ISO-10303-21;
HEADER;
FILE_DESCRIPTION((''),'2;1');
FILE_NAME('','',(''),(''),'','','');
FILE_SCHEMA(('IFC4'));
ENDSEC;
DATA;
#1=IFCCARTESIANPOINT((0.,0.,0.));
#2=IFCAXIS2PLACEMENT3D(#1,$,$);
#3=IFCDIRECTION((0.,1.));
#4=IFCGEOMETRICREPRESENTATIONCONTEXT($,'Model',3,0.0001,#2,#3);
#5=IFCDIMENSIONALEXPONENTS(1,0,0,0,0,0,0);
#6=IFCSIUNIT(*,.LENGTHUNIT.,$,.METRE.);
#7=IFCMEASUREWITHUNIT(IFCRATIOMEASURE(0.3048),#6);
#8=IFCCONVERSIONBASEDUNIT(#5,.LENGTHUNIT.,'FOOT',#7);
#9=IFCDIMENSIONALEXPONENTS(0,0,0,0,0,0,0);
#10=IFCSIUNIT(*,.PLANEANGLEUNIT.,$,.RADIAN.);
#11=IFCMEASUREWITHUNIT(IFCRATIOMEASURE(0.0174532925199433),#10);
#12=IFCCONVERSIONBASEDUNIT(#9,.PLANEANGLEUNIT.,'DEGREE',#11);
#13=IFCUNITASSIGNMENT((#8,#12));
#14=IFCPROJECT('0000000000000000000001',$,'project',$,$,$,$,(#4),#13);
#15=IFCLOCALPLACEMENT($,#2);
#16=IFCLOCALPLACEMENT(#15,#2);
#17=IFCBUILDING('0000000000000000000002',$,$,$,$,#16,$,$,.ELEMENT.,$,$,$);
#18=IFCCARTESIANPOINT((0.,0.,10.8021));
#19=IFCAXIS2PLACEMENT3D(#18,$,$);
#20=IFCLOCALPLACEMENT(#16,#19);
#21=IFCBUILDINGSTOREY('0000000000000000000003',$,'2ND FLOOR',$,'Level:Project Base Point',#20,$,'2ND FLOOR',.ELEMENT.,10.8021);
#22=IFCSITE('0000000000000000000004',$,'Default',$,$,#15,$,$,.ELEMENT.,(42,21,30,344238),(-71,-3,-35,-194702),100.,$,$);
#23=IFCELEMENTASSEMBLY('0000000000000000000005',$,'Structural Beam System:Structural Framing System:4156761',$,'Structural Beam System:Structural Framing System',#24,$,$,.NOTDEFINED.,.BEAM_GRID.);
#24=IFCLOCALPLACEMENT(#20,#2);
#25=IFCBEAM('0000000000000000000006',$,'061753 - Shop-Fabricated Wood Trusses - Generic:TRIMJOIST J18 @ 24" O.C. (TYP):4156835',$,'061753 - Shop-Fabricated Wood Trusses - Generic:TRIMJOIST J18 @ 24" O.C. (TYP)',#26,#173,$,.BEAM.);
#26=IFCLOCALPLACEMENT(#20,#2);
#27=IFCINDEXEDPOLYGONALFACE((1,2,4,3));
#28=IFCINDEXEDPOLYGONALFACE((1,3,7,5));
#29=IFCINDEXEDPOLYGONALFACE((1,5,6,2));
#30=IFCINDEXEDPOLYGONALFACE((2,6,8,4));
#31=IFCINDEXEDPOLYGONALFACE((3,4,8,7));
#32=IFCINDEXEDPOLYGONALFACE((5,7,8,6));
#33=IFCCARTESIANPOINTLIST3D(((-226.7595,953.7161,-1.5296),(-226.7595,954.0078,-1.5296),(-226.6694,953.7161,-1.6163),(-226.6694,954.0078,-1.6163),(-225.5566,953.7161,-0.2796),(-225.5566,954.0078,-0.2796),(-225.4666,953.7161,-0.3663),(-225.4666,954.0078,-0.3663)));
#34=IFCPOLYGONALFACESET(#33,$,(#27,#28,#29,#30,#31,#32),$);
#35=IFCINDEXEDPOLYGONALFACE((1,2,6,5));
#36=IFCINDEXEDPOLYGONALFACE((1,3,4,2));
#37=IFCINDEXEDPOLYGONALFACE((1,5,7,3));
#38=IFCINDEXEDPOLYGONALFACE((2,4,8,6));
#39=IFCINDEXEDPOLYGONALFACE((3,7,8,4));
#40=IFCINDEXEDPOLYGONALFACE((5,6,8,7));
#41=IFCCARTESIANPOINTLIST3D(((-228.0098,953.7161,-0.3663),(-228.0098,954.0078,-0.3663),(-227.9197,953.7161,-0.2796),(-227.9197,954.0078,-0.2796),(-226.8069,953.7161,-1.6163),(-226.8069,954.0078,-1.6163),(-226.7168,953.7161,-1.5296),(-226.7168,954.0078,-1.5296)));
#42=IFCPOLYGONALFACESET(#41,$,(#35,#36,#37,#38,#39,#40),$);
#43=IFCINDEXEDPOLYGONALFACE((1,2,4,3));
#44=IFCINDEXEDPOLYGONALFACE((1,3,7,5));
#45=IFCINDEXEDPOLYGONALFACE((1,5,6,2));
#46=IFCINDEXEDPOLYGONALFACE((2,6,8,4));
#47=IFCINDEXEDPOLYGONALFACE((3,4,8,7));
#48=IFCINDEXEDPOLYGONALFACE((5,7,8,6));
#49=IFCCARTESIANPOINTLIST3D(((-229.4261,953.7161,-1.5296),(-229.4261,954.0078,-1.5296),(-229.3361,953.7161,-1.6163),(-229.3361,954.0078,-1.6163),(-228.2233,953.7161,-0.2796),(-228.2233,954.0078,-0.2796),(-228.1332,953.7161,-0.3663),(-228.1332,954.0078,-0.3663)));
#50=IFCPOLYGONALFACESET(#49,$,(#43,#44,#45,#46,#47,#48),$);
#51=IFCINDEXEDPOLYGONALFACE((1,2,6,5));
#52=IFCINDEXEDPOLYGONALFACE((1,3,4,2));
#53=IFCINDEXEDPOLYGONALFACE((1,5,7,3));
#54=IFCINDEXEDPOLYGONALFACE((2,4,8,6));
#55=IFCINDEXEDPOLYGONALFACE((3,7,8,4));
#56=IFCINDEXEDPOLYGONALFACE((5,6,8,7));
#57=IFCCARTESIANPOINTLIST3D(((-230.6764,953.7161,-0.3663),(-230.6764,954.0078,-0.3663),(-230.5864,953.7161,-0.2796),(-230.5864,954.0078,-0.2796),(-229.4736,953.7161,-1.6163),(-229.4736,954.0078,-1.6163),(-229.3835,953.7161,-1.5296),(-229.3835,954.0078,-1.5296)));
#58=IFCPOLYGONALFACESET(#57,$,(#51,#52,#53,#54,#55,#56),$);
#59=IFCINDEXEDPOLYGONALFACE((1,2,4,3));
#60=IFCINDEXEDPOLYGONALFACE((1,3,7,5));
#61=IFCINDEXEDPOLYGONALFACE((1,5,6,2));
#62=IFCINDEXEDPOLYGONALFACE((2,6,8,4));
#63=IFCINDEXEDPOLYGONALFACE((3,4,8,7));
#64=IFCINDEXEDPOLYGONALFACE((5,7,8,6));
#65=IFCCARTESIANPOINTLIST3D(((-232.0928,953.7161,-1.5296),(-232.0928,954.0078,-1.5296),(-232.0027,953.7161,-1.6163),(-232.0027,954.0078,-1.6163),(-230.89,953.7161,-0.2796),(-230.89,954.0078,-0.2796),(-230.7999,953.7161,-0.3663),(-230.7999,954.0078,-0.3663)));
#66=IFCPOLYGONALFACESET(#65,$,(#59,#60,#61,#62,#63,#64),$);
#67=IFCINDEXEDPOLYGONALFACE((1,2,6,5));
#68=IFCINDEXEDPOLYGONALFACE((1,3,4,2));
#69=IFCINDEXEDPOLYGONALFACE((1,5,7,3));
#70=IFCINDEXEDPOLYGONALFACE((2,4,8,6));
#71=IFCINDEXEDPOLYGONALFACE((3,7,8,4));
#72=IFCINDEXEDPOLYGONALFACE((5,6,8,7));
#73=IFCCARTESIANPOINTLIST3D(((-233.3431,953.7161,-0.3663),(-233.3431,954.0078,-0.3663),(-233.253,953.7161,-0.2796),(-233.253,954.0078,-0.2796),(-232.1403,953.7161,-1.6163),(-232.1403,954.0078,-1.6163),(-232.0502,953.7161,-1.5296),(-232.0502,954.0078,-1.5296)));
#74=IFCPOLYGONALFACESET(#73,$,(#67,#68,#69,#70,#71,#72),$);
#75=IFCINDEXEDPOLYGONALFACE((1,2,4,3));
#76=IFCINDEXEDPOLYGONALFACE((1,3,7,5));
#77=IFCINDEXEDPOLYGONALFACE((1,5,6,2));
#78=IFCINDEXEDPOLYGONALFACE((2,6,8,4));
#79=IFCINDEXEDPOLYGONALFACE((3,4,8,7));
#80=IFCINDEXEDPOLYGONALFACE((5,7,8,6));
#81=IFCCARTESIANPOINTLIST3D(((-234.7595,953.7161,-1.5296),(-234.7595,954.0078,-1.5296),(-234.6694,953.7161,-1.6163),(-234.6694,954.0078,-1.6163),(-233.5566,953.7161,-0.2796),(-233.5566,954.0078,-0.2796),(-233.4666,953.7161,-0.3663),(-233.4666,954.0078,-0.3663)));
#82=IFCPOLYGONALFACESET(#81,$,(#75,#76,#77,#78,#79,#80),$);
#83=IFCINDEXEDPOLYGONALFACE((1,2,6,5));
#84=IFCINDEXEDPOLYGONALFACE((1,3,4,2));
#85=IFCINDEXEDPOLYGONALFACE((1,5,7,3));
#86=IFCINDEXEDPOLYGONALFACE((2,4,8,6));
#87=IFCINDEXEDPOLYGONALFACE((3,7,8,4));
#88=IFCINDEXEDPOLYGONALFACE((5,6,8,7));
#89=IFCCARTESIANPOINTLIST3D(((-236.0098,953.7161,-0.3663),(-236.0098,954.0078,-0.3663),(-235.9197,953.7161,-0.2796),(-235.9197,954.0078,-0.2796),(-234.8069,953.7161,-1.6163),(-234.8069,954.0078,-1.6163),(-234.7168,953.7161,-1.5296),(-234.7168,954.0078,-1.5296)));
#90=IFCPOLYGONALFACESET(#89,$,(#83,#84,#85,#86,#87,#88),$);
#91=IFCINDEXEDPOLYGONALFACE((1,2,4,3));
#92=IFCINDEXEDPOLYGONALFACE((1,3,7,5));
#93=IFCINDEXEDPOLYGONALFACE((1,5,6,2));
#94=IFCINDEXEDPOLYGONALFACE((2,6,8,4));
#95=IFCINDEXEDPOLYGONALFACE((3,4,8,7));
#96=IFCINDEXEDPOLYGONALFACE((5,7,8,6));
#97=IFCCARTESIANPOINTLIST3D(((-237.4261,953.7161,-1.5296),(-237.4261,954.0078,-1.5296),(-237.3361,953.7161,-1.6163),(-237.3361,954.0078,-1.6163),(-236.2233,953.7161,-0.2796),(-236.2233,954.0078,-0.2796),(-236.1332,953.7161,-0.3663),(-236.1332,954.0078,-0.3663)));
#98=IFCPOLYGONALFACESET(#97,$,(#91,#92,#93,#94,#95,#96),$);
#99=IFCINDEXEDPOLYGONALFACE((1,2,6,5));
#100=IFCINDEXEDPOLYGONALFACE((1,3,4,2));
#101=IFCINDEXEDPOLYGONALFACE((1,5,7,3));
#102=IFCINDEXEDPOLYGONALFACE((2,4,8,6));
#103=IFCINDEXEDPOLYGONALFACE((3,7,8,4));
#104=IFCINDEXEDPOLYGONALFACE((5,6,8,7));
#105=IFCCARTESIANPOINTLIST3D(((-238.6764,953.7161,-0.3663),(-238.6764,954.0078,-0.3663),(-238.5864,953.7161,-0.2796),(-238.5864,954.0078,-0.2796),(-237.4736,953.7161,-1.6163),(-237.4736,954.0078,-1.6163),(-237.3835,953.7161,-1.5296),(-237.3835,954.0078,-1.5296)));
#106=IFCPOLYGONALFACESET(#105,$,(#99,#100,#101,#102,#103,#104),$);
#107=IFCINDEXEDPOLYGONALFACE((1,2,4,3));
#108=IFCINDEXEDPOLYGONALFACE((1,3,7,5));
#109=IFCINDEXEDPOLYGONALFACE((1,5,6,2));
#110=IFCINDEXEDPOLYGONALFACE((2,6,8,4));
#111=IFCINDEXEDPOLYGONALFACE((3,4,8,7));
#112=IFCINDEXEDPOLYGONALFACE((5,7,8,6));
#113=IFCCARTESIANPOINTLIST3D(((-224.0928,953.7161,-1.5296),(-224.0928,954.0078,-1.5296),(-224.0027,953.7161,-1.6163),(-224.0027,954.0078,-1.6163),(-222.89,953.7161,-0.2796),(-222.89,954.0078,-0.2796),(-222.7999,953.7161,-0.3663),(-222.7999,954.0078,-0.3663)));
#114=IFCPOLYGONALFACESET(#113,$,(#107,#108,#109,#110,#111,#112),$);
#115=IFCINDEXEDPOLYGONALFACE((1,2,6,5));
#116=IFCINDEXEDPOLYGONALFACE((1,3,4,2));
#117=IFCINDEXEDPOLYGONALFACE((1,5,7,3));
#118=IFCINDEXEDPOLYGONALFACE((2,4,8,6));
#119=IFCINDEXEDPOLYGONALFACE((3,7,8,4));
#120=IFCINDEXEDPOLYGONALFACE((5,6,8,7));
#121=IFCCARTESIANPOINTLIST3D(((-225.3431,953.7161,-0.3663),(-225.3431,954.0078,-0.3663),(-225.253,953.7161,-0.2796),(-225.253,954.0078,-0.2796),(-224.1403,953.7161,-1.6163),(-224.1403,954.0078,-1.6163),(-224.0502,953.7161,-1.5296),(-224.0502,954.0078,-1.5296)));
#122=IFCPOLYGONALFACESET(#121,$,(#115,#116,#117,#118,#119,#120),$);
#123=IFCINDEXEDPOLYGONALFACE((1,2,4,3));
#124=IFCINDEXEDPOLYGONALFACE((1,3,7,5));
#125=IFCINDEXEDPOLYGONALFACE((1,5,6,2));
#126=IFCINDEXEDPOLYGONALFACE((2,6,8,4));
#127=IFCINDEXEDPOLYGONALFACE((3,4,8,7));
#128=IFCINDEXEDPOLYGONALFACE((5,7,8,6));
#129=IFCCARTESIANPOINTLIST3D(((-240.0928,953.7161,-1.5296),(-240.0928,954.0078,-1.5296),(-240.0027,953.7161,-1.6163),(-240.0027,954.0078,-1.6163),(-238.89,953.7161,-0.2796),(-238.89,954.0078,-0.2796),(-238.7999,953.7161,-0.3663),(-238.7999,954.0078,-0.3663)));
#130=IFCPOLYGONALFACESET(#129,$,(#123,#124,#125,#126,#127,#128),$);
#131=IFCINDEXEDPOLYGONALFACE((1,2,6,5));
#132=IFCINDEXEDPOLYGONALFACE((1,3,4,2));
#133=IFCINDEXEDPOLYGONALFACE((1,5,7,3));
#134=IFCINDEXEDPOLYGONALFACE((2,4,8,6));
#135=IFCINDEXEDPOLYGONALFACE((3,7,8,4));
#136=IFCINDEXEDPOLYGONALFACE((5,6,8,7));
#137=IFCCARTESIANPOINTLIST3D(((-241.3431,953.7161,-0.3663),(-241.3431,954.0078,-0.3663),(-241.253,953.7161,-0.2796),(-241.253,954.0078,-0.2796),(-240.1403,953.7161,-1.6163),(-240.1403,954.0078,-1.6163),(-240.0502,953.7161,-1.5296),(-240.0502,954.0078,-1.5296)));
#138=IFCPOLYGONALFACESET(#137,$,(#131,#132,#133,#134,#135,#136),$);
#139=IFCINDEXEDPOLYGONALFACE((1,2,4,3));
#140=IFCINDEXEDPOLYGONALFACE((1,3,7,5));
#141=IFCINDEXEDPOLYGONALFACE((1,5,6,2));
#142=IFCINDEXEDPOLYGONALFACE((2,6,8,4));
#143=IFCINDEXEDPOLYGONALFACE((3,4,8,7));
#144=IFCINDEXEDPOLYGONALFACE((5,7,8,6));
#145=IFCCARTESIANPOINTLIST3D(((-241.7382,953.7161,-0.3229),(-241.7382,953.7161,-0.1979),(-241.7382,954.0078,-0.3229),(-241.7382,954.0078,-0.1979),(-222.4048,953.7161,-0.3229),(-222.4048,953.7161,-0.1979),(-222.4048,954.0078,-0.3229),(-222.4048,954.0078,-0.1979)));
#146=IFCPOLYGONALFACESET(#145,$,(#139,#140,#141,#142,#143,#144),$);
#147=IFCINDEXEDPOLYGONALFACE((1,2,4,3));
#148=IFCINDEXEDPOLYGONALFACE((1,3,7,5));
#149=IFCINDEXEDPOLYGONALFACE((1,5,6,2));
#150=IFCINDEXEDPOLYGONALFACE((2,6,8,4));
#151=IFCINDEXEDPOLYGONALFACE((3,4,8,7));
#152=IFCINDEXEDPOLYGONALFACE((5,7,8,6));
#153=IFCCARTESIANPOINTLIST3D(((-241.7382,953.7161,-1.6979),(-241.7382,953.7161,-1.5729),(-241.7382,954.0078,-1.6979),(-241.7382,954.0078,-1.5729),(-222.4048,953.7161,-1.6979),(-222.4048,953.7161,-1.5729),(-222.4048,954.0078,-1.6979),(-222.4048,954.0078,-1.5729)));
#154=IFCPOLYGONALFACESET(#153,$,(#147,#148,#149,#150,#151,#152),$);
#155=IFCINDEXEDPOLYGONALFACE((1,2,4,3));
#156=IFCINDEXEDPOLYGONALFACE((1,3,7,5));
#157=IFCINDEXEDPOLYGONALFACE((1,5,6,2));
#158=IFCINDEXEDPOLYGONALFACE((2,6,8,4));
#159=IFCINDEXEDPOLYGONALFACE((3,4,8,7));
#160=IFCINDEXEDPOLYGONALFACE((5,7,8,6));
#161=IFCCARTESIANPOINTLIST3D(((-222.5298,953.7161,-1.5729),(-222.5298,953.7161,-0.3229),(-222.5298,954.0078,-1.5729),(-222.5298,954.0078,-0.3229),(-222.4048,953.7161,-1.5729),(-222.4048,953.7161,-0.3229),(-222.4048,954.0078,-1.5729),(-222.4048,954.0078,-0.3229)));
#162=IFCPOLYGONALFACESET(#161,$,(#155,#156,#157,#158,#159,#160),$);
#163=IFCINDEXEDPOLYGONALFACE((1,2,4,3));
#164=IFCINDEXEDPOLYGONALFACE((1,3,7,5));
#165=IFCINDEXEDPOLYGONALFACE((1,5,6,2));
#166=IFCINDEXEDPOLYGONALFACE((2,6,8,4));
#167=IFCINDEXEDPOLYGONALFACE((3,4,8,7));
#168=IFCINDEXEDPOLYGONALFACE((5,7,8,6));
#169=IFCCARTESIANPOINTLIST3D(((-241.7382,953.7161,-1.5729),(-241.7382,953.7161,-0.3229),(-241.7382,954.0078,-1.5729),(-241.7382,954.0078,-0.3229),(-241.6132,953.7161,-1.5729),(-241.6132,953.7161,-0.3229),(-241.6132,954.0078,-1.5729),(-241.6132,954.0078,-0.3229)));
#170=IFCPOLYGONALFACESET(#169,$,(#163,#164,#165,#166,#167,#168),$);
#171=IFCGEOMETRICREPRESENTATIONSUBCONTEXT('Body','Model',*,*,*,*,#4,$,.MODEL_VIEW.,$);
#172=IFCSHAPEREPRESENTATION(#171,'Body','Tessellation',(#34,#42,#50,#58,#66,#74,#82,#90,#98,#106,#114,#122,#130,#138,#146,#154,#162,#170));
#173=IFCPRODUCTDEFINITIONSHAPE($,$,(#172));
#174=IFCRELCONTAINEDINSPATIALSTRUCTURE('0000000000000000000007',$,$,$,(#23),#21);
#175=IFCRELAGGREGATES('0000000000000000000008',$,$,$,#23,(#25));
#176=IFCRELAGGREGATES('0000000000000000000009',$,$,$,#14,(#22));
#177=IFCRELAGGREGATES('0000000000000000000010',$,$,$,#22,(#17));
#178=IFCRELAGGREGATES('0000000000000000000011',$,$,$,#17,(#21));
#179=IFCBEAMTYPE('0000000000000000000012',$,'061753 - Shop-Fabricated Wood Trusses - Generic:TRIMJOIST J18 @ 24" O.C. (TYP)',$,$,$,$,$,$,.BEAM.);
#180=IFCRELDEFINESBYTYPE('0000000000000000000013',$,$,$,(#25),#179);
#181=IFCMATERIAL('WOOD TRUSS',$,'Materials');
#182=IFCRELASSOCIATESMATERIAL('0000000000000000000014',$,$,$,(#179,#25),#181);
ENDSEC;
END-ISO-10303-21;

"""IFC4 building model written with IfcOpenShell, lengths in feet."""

from ifc_helpers import new_model, entity, si_unit, converted_unit, direction, frame, frame_2d, origin, origin_2d_with_axis, place, context, subcontext, project, spatial, rectangle, extrude, source, transform, mapped, material, material_profile, profile_set, profile_usage, type_object, type_shapes, element, aggregate, save


model = new_model("IFC4")

# Units and contexts
model_context = context("Model", 3, precision=0.0001, world=origin(), true_north=direction((0.0, 1.0)))
body_context = subcontext(model_context, "Body", "Model", "MODEL_VIEW")
ifc_project = project(units=[converted_unit("LENGTHUNIT", "FOOT", entity("IfcRatioMeasure", 0.3048), si_unit("LENGTHUNIT", "METRE"), dimensions=[1, 0, 0, 0, 0, 0, 0]), converted_unit("PLANEANGLEUNIT", "DEGREE", entity("IfcRatioMeasure", 0.0174532925199433), si_unit("PLANEANGLEUNIT", "RADIAN"), dimensions=[0, 0, 0, 0, 0, 0, 0])], contexts=[model_context])

# Site, building, storey
site_placement = place(None, origin())
site = spatial("IfcSite", under=ifc_project, at=site_placement, Name="Default", CompositionType="ELEMENT", RefLatitude=(42, 21, 30, 344238), RefLongitude=(-71, -3, -35, -194702), RefElevation=100.0)
building_placement = place(site_placement, origin())
building = spatial("IfcBuilding", under=site, at=building_placement, CompositionType="ELEMENT")
storey_placement = place(building_placement, frame((0.0, 0.0, 10.8021)))
storey = spatial("IfcBuildingStorey", under=building, at=storey_placement, Name="2ND FLOOR", ObjectType="Level:Project Base Point", LongName="2ND FLOOR", CompositionType="ELEMENT", Elevation=10.8021)

# Element assembly, beam
assembly_1_placement = place(storey_placement, origin())
assembly_1 = element("IfcElementAssembly", 1, at=assembly_1_placement, inside=storey, Name="Structural Beam System:Structural Framing System:4156761", ObjectType="Structural Beam System:Structural Framing System", AssemblyPlace="NOTDEFINED", PredefinedType="BEAM_GRID")
ifc_material_1 = material(Name="WOOD TRUSS", Category="Materials")
ifc_material_profile_1 = material_profile(ifc_material_1, rectangle(XDim=1.7347, YDim=0.125, at=frame_2d((0.0, 0.0), x_axis=(1.0, 0.0))), Name="TRIMJOIST J18 @ 24\" O.C. (TYP)")
ifc_material_profile_2 = material_profile(ifc_material_1, rectangle(XDim=1.7347, YDim=0.125, at=frame_2d((0.0, 0.0), x_axis=(1.0, 0.0))), Name="TRIMJOIST J18 @ 24\" O.C. (TYP)")
ifc_material_profile_3 = material_profile(ifc_material_1, rectangle(XDim=1.7347, YDim=0.125, at=frame_2d((0.0, 0.0), x_axis=(1.0, 0.0))), Name="TRIMJOIST J18 @ 24\" O.C. (TYP)")
ifc_material_profile_4 = material_profile(ifc_material_1, rectangle(XDim=1.7347, YDim=0.125, at=frame_2d((0.0, 0.0), x_axis=(1.0, 0.0))), Name="TRIMJOIST J18 @ 24\" O.C. (TYP)")
ifc_material_profile_5 = material_profile(ifc_material_1, rectangle(XDim=1.7347, YDim=0.125, at=frame_2d((0.0, 0.0), x_axis=(1.0, 0.0))), Name="TRIMJOIST J18 @ 24\" O.C. (TYP)")
ifc_material_profile_6 = material_profile(ifc_material_1, rectangle(XDim=1.7347, YDim=0.125, at=frame_2d((0.0, 0.0), x_axis=(1.0, 0.0))), Name="TRIMJOIST J18 @ 24\" O.C. (TYP)")
ifc_material_profile_7 = material_profile(ifc_material_1, rectangle(XDim=1.7347, YDim=0.125, at=frame_2d((0.0, 0.0), x_axis=(1.0, 0.0))), Name="TRIMJOIST J18 @ 24\" O.C. (TYP)")
ifc_material_profile_8 = material_profile(ifc_material_1, rectangle(XDim=1.7347, YDim=0.125, at=frame_2d((0.0, 0.0), x_axis=(1.0, 0.0))), Name="TRIMJOIST J18 @ 24\" O.C. (TYP)")
ifc_material_profile_9 = material_profile(ifc_material_1, rectangle(XDim=1.7347, YDim=0.125, at=frame_2d((0.0, 0.0), x_axis=(1.0, 0.0))), Name="TRIMJOIST J18 @ 24\" O.C. (TYP)")
ifc_material_profile_10 = material_profile(ifc_material_1, rectangle(XDim=1.7347, YDim=0.125, at=origin_2d_with_axis()), Name="TRIMJOIST J18 @ 24\" O.C. (TYP)")
ifc_material_profile_11 = material_profile(ifc_material_1, rectangle(XDim=0.125, YDim=0.2917, at=origin_2d_with_axis()), Name="TRIMJOIST J18 @ 24\" O.C. (TYP)")
ifc_material_profile_12 = material_profile(ifc_material_1, rectangle(XDim=0.125, YDim=0.2917, at=origin_2d_with_axis()), Name="TRIMJOIST J18 @ 24\" O.C. (TYP)")
ifc_material_profile_13 = material_profile(ifc_material_1, rectangle(XDim=1.25, YDim=0.2917, at=origin_2d_with_axis()), Name="TRIMJOIST J18 @ 24\" O.C. (TYP)")
ifc_material_profile_14 = material_profile(ifc_material_1, rectangle(XDim=1.25, YDim=0.2917, at=origin_2d_with_axis()), Name="TRIMJOIST J18 @ 24\" O.C. (TYP)")
ifc_profile_set_1 = profile_set([ifc_material_profile_1, ifc_material_profile_2, ifc_material_profile_3, ifc_material_profile_4, ifc_material_profile_5, ifc_material_profile_6, ifc_material_profile_7, ifc_material_profile_8, ifc_material_profile_9, ifc_material_profile_10, ifc_material_profile_11, ifc_material_profile_12, ifc_material_profile_13, ifc_material_profile_14], Name="TRIMJOIST J18 @ 24\" O.C. (TYP)")
ifc_profile_usage_1 = profile_usage(ifc_profile_set_1, cardinal=8)
beam_type_1 = type_object("IfcBeamType", Name="061753 - Shop-Fabricated Wood Trusses - Generic:TRIMJOIST J18 @ 24\" O.C. (TYP)", PredefinedType="BEAM", material=ifc_profile_set_1)
shared_shape_1 = source(origin(), body_context, "Body", "SweptSolid", [
    extrude(rectangle(XDim=1.7347, YDim=0.125, at=frame_2d((0.0, 0.0), x_axis=(1.0, 0.0))), frame((5.9585, -0.1458, 0.0), z_axis=(0.0, 1.0, 0.0), x_axis=(0.693383, 0.0, 0.720569)), (0.0, 0.0, 1.0), 0.2917),
    extrude(rectangle(XDim=1.7347, YDim=0.125, at=origin_2d_with_axis()), frame((4.7082, -0.1458, 0.0), z_axis=(0.0, 1.0, 0.0), x_axis=(0.693383, 0.0, -0.720569)), (0.0, 0.0, 1.0), 0.2917),
    extrude(rectangle(XDim=1.7347, YDim=0.125, at=frame_2d((0.0, 0.0), x_axis=(1.0, 0.0))), frame((3.2918, -0.1458, 0.0), z_axis=(0.0, 1.0, 0.0), x_axis=(0.693383, 0.0, 0.720569)), (0.0, 0.0, 1.0), 0.2917),
    extrude(rectangle(XDim=1.7347, YDim=0.125, at=frame_2d((0.0, 0.0), x_axis=(1.0, 0.0))), frame((2.0415, -0.1458, 0.0), z_axis=(0.0, 1.0, 0.0), x_axis=(0.693383, 0.0, -0.720569)), (0.0, 0.0, 1.0), 0.2917),
    extrude(rectangle(XDim=1.7347, YDim=0.125, at=frame_2d((0.0, 0.0), x_axis=(1.0, 0.0))), frame((0.6251, -0.1458, 0.0), z_axis=(0.0, 1.0, 0.0), x_axis=(0.693383, 0.0, 0.720569)), (0.0, 0.0, 1.0), 0.2917),
    extrude(rectangle(XDim=1.7347, YDim=0.125, at=frame_2d((0.0, 0.0), x_axis=(1.0, 0.0))), frame((-0.6251, -0.1458, 0.0), z_axis=(0.0, 1.0, 0.0), x_axis=(0.693383, 0.0, -0.720569)), (0.0, 0.0, 1.0), 0.2917),
    extrude(rectangle(XDim=1.7347, YDim=0.125, at=frame_2d((0.0, 0.0), x_axis=(1.0, 0.0))), frame((-2.0415, -0.1458, 0.0), z_axis=(0.0, 1.0, 0.0), x_axis=(0.693383, 0.0, 0.720569)), (0.0, 0.0, 1.0), 0.2917),
    extrude(rectangle(XDim=1.7347, YDim=0.125, at=origin_2d_with_axis()), frame((-3.2918, -0.1458, 0.0), z_axis=(0.0, 1.0, 0.0), x_axis=(0.693383, 0.0, -0.720569)), (0.0, 0.0, 1.0), 0.2917),
    extrude(rectangle(XDim=1.7347, YDim=0.125, at=frame_2d((0.0, 0.0), x_axis=(1.0, 0.0))), frame((-4.7082, -0.1458, 0.0), z_axis=(0.0, 1.0, 0.0), x_axis=(0.693383, 0.0, 0.720569)), (0.0, 0.0, 1.0), 0.2917),
    extrude(rectangle(XDim=1.7347, YDim=0.125, at=frame_2d((0.0, 0.0), x_axis=(1.0, 0.0))), frame((-5.9585, -0.1458, 0.0), z_axis=(0.0, 1.0, 0.0), x_axis=(0.693383, 0.0, -0.720569)), (0.0, 0.0, 1.0), 0.2917),
    extrude(rectangle(XDim=1.7347, YDim=0.125, at=frame_2d((0.0, 0.0), x_axis=(1.0, 0.0))), frame((8.6251, -0.1458, 0.0), z_axis=(0.0, 1.0, 0.0), x_axis=(0.693383, 0.0, 0.720569)), (0.0, 0.0, 1.0), 0.2917),
    extrude(rectangle(XDim=1.7347, YDim=0.125, at=origin_2d_with_axis()), frame((7.3749, -0.1458, 0.0), z_axis=(0.0, 1.0, 0.0), x_axis=(0.693383, 0.0, -0.720569)), (0.0, 0.0, 1.0), 0.2917),
    extrude(rectangle(XDim=1.7347, YDim=0.125, at=frame_2d((0.0, 0.0), x_axis=(1.0, 0.0))), frame((-7.3749, -0.1458, 0.0), z_axis=(0.0, 1.0, 0.0), x_axis=(0.693383, 0.0, 0.720569)), (0.0, 0.0, 1.0), 0.2917),
    extrude(rectangle(XDim=1.7347, YDim=0.125, at=origin_2d_with_axis()), frame((-8.6251, -0.1458, 0.0), z_axis=(0.0, 1.0, 0.0), x_axis=(0.693383, 0.0, -0.720569)), (0.0, 0.0, 1.0), 0.2917),
    extrude(rectangle(XDim=0.125, YDim=0.2917, at=origin_2d_with_axis()), frame((-9.6667, 0.0, 0.6875), z_axis=(1.0, 0.0, 0.0), x_axis=(0.0, 0.0, -1.0)), (0.0, 0.0, 1.0), 19.3333),
    extrude(rectangle(XDim=0.125, YDim=0.2917, at=origin_2d_with_axis()), frame((-9.6667, 0.0, -0.6875), z_axis=(1.0, 0.0, 0.0), x_axis=(0.0, 0.0, -1.0)), (0.0, 0.0, 1.0), 19.3333),
    extrude(rectangle(XDim=1.25, YDim=0.2917, at=origin_2d_with_axis()), frame((9.5417, 0.0, 0.0), z_axis=(1.0, 0.0, 0.0), x_axis=(0.0, 0.0, -1.0)), (0.0, 0.0, 1.0), 0.125),
    extrude(rectangle(XDim=1.25, YDim=0.2917, at=origin_2d_with_axis()), frame((-9.6667, 0.0, 0.0), z_axis=(1.0, 0.0, 0.0), x_axis=(0.0, 0.0, -1.0)), (0.0, 0.0, 1.0), 0.125),
])
type_shapes(beam_type_1, [shared_shape_1])
beam_1_placement = place(assembly_1_placement, frame((-232.0715, 953.8619, -0.9479)))
beam_1 = element("IfcBeam", 2, at=beam_1_placement, type_object=beam_type_1, material=ifc_profile_usage_1, Name="061753 - Shop-Fabricated Wood Trusses - Generic:TRIMJOIST J18 @ 24\" O.C. (TYP):4156835", ObjectType="061753 - Shop-Fabricated Wood Trusses - Generic:TRIMJOIST J18 @ 24\" O.C. (TYP)", PredefinedType="BEAM", context=body_context, shape_type="MappedRepresentation", body=[
    mapped(shared_shape_1, transform((0.0, 0.0, 0.0), scale=1.0)),
])
aggregate(assembly_1, [beam_1])

save(model, "model.ifc")
